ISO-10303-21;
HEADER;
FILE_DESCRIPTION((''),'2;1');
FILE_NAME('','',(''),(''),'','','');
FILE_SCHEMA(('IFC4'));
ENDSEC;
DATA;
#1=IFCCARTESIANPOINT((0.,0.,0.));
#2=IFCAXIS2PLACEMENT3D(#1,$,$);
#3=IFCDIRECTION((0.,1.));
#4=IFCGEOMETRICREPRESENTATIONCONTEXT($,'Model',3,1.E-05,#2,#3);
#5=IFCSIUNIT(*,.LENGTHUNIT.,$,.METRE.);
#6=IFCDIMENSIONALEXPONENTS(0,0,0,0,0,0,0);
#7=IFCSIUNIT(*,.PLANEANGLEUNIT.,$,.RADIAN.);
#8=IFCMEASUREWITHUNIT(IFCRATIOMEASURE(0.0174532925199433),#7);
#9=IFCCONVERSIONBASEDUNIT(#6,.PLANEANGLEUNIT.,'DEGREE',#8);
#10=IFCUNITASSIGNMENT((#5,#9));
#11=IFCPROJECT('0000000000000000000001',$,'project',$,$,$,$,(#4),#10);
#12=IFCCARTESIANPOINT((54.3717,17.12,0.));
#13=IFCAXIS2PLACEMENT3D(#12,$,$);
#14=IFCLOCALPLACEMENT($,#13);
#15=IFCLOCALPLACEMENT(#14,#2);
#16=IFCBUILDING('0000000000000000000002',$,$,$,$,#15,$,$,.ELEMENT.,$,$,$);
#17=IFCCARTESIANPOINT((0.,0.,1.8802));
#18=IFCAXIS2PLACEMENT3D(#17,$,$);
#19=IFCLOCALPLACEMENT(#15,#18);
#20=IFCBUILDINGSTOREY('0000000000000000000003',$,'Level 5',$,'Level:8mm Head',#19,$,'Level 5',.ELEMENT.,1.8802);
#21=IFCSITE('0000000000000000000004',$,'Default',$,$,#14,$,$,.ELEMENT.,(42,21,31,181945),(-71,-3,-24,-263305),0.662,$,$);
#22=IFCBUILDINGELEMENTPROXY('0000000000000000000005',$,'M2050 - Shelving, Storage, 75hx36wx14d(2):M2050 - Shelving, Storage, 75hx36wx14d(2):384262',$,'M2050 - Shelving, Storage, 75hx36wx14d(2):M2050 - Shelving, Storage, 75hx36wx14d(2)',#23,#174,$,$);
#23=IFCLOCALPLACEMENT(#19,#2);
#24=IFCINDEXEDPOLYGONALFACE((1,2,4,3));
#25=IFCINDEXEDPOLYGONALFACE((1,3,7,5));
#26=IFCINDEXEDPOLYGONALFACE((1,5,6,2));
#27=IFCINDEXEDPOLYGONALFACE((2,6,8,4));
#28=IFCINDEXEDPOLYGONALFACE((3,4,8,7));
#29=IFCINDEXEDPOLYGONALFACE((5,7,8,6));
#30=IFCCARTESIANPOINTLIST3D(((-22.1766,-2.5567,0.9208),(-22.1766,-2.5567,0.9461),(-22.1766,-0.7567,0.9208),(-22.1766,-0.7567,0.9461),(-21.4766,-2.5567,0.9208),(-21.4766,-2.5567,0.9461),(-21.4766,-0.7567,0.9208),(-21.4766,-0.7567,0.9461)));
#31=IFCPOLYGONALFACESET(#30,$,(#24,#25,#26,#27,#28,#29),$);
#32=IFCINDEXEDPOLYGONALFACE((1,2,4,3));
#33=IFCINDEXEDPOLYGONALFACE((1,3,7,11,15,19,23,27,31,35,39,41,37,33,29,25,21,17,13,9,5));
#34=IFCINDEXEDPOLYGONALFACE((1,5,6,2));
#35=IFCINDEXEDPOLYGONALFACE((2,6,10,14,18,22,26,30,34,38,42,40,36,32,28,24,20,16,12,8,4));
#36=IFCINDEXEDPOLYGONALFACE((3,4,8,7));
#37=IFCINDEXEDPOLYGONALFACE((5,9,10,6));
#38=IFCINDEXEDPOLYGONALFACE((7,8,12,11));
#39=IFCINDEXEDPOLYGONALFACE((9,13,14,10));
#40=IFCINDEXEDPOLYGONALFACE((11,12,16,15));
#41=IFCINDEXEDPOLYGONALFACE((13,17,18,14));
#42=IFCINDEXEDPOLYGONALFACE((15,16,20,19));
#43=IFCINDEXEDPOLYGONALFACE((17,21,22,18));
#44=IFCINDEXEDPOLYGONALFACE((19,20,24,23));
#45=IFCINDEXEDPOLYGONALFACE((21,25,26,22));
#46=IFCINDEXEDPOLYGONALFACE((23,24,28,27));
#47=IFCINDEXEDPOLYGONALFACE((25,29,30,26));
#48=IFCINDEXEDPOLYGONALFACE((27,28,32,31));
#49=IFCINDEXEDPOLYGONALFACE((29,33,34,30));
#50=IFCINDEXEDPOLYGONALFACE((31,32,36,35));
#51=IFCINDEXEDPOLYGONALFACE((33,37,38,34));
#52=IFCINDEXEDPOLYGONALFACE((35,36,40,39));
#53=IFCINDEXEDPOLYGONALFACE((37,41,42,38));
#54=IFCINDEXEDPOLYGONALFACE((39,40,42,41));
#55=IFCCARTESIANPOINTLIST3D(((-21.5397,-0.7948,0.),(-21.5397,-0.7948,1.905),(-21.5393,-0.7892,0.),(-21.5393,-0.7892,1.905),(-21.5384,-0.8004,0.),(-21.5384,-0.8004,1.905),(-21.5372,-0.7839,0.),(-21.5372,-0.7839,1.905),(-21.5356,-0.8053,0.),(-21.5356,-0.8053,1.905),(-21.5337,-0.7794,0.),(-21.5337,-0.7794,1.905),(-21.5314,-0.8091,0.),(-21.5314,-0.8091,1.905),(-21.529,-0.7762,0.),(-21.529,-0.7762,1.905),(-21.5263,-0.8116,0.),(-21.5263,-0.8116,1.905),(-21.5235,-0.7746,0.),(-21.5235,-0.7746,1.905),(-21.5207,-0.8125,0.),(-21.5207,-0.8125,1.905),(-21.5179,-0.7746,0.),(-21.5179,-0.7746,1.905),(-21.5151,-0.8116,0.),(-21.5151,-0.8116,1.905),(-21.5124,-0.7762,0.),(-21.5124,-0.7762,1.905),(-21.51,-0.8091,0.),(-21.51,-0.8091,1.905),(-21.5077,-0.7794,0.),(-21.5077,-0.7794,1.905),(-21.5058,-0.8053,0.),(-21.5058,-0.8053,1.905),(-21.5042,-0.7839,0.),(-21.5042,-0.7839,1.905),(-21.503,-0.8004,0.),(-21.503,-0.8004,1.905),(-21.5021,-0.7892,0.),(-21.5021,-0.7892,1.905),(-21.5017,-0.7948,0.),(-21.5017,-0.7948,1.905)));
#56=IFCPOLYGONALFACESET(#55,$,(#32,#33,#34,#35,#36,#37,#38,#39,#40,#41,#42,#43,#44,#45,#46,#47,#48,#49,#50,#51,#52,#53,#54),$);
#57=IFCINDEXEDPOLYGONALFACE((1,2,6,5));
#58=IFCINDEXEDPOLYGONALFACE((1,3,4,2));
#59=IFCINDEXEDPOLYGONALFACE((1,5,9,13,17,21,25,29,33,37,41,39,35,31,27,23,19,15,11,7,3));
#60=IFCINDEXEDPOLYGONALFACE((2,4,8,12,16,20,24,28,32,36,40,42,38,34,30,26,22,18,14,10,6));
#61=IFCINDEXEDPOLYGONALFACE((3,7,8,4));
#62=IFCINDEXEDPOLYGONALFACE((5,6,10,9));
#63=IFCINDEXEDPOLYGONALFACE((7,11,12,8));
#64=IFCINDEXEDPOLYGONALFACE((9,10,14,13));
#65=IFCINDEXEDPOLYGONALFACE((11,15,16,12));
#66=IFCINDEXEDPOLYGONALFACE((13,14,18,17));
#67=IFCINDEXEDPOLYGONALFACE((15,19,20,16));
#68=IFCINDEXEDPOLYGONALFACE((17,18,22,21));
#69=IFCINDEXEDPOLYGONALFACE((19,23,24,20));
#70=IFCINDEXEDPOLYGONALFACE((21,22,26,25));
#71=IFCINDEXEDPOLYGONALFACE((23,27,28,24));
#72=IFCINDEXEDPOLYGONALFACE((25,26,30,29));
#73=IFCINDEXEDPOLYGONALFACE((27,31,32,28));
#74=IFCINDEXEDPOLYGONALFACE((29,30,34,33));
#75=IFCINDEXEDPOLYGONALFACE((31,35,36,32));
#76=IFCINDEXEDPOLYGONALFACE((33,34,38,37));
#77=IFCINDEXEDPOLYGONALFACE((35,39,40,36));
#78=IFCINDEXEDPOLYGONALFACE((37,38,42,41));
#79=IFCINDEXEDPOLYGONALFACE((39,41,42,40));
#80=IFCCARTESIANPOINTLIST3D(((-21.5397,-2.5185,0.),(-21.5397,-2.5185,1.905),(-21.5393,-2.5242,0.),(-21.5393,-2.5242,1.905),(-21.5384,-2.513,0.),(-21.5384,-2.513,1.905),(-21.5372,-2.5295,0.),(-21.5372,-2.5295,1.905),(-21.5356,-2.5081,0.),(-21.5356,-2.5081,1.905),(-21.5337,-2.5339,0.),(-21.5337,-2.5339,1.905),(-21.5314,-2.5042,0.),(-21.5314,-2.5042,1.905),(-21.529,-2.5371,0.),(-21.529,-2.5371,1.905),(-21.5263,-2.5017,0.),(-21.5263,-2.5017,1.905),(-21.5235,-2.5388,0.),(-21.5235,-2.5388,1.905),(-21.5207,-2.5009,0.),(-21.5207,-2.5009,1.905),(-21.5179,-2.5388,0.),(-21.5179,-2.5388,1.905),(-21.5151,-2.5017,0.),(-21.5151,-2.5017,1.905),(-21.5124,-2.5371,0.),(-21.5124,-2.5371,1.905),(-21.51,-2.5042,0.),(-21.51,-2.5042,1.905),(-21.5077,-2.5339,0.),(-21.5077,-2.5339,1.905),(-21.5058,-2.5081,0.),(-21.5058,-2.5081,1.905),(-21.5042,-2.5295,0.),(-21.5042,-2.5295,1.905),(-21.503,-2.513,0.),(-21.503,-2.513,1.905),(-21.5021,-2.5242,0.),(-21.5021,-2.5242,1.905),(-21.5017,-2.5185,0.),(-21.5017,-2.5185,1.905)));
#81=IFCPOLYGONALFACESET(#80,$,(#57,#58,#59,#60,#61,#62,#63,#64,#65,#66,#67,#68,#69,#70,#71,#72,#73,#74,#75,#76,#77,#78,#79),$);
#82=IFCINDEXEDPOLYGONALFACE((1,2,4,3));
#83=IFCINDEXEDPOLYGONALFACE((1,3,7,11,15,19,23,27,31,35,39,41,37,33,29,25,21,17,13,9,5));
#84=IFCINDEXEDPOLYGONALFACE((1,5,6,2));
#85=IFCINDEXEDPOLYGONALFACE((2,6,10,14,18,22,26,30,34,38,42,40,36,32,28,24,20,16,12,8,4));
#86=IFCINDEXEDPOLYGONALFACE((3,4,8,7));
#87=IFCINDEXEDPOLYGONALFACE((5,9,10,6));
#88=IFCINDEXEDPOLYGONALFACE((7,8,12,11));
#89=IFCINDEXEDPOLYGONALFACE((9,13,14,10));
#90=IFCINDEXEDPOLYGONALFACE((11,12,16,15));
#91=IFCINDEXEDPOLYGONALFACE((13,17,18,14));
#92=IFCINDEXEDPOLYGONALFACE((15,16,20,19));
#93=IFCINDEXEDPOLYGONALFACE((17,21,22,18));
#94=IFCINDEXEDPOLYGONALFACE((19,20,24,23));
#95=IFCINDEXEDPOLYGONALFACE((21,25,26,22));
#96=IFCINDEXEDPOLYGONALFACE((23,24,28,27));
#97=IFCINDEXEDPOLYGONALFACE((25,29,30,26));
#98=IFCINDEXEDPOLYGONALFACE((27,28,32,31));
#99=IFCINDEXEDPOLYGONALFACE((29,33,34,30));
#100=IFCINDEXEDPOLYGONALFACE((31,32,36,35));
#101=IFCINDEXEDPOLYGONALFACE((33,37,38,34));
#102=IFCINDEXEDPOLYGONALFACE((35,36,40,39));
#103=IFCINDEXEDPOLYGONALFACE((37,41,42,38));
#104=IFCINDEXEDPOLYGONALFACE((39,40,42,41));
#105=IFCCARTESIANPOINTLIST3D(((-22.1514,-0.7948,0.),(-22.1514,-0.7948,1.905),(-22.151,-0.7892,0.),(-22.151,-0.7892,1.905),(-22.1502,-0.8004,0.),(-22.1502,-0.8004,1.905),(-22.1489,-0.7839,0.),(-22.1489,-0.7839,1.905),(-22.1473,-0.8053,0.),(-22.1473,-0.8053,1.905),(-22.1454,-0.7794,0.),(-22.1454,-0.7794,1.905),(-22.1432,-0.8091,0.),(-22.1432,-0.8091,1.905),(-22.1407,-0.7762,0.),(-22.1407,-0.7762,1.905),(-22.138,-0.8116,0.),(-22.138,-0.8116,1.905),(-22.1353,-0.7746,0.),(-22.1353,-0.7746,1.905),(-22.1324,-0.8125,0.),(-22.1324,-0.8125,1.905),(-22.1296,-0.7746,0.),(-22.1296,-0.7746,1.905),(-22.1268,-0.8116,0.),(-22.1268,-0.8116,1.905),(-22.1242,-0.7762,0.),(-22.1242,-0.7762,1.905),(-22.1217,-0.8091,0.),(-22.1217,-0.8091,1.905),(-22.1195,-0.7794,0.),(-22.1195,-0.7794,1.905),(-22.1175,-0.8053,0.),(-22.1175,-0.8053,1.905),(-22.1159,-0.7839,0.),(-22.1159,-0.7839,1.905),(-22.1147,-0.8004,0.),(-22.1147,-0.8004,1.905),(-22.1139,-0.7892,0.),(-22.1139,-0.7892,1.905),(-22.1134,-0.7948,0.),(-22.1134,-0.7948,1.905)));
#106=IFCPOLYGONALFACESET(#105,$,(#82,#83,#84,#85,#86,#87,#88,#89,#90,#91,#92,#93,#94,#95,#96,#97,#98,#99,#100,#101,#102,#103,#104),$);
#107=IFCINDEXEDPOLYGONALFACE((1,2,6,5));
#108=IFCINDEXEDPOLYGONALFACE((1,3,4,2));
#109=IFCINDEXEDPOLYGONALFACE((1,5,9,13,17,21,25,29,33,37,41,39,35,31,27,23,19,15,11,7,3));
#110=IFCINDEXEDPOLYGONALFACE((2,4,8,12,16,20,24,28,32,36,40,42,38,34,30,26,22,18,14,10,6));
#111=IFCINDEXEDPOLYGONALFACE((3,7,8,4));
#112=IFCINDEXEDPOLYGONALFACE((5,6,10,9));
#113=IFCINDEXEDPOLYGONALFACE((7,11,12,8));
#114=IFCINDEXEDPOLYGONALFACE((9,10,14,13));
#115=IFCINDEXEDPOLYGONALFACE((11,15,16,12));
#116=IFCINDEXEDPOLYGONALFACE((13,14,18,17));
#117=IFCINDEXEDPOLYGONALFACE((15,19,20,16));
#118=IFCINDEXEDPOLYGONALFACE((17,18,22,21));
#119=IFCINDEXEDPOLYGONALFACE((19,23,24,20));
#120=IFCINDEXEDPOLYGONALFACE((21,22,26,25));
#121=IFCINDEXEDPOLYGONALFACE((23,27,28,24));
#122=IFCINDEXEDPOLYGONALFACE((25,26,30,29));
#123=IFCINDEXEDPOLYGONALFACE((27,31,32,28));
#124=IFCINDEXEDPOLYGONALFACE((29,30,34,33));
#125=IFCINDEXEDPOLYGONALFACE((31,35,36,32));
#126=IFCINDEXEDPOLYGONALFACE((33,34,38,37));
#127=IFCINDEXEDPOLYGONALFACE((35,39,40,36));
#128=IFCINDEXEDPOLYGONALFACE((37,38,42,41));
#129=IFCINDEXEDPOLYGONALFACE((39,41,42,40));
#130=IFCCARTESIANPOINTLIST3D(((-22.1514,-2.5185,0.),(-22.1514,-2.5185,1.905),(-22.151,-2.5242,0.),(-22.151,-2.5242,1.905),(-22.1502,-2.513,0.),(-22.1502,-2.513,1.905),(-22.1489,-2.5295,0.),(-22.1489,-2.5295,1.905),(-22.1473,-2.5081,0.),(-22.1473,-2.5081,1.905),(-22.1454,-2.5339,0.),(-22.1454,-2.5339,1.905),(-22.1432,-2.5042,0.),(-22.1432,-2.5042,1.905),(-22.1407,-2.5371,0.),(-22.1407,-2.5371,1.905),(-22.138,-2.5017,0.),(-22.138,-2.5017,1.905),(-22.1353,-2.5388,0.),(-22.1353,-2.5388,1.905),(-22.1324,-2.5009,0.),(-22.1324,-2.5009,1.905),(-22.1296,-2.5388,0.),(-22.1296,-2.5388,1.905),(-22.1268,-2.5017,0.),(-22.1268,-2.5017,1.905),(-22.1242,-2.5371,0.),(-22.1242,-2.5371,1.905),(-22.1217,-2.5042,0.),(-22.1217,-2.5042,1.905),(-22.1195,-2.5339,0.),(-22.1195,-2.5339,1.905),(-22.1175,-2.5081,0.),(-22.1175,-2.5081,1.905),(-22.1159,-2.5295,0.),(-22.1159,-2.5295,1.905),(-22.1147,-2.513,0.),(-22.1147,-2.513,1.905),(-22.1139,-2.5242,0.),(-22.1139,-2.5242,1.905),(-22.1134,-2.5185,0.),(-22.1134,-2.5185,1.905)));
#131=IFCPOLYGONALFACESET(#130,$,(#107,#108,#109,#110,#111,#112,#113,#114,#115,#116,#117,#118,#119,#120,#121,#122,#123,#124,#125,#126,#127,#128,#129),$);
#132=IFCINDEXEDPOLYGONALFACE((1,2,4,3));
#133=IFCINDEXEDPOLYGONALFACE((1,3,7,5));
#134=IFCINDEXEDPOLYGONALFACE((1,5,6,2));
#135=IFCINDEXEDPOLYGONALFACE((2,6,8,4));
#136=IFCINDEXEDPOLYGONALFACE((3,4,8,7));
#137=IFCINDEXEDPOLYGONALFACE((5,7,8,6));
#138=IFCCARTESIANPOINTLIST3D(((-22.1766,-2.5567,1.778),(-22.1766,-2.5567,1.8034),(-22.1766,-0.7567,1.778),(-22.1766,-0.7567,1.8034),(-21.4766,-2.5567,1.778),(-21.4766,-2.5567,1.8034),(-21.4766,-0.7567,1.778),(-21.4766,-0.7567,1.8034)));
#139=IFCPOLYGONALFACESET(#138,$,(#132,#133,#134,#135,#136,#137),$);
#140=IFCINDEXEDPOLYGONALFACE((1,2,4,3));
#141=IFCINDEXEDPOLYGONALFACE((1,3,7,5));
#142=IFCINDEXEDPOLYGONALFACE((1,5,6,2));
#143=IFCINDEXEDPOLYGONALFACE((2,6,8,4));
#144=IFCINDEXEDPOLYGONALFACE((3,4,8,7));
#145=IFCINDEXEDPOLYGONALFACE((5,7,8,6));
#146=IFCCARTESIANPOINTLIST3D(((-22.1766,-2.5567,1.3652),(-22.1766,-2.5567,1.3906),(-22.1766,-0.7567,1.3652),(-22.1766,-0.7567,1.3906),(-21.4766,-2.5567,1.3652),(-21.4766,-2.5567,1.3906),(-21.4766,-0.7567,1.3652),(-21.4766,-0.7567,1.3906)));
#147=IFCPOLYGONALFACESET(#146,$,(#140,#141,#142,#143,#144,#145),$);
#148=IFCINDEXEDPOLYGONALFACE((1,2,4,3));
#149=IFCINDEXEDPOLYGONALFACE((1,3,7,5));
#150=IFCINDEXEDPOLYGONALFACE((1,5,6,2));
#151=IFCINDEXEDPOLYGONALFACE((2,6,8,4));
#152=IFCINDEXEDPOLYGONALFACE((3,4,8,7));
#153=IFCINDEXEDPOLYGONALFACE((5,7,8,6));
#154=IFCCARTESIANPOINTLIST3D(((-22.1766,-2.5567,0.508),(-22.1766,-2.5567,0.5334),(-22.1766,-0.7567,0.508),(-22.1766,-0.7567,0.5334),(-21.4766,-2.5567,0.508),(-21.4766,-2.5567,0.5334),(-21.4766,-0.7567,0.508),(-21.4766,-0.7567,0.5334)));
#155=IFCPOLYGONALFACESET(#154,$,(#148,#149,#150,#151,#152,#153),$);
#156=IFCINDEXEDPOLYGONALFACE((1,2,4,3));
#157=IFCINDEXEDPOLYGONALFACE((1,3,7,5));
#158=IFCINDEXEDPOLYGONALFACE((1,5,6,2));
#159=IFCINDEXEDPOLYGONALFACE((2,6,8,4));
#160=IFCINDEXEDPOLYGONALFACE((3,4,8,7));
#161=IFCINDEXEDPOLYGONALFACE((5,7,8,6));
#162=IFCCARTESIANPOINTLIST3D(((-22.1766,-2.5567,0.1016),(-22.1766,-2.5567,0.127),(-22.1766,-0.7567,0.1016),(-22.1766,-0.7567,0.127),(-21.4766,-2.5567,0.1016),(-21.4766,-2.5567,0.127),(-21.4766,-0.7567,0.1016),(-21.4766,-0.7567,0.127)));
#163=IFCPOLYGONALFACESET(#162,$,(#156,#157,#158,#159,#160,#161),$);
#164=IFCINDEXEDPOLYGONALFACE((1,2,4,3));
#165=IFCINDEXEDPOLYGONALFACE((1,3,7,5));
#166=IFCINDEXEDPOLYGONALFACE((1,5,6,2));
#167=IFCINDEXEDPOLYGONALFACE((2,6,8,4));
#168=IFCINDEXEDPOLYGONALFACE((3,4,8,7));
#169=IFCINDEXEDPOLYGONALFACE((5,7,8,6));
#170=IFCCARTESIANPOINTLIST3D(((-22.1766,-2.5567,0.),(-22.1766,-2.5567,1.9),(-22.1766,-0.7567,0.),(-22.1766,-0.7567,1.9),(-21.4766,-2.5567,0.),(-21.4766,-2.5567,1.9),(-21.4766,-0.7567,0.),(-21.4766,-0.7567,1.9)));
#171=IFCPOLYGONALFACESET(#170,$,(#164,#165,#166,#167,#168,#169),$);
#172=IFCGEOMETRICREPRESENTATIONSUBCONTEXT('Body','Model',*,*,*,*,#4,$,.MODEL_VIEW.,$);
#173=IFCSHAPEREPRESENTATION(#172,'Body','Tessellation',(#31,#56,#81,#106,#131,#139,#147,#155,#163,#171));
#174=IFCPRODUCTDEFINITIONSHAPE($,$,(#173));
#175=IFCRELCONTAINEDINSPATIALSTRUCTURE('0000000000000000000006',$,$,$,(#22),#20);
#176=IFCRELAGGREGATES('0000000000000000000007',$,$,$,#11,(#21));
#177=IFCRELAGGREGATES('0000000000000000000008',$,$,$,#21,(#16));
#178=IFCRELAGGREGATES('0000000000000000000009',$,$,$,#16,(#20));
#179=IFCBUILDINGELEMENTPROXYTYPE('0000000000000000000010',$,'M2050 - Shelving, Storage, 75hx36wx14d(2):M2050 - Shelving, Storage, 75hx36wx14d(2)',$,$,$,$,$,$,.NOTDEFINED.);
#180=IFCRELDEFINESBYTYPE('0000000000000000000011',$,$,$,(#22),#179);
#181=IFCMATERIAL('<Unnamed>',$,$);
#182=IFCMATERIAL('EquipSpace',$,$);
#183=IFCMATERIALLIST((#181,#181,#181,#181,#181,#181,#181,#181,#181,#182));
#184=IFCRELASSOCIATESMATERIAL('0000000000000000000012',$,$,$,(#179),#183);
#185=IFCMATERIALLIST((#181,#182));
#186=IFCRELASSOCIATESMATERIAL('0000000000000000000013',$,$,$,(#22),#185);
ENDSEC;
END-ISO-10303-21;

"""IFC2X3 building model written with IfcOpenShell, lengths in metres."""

from ifc_helpers import new_model, entity, si_unit, converted_unit, direction, frame, frame_2d, origin, origin_2d_with_axis, place, context, subcontext, project, spatial, rectangle, circle, extrude, source, transform, mapped, material, material_list, type_object, type_shapes, element, save


model = new_model("IFC2X3")

# Units and contexts
model_context = context("Model", 3, precision=1e-05, world=origin(), true_north=direction((0.0, 1.0)))
body_context = subcontext(model_context, "Body", "Model", "MODEL_VIEW")
ifc_project = project(units=[si_unit("LENGTHUNIT", "METRE"), converted_unit("PLANEANGLEUNIT", "DEGREE", entity("IfcRatioMeasure", 0.0174532925199433), si_unit("PLANEANGLEUNIT", "RADIAN"), dimensions=[0, 0, 0, 0, 0, 0, 0])], contexts=[model_context])

# Site, building, storey
site_placement = place(None, frame((54.3717, 17.12, 0.0)))
site = spatial("IfcSite", under=ifc_project, at=site_placement, Name="Default", CompositionType="ELEMENT", RefLatitude=(42, 21, 31, 181945), RefLongitude=(-71, -3, -24, -263305), RefElevation=0.662)
building_placement = place(site_placement, origin())
building = spatial("IfcBuilding", under=site, at=building_placement, CompositionType="ELEMENT")
storey_placement = place(building_placement, frame((0.0, 0.0, 1.8802)))
storey = spatial("IfcBuildingStorey", under=building, at=storey_placement, Name="Level 5", ObjectType="Level:8mm Head", LongName="Level 5", CompositionType="ELEMENT", Elevation=1.8802)

# Building element proxy
ifc_material_1 = material(Name="<Unnamed>")
ifc_material_2 = material(Name="EquipSpace")
ifc_material_list_1 = material_list([ifc_material_1, ifc_material_1, ifc_material_1, ifc_material_1, ifc_material_1, ifc_material_1, ifc_material_1, ifc_material_1, ifc_material_1, ifc_material_2])
building_element_proxy_type = type_object("IfcBuildingElementProxyType", Name="M2050 - Shelving, Storage, 75hx36wx14d(2):M2050 - Shelving, Storage, 75hx36wx14d(2)", PredefinedType="NOTDEFINED", material=ifc_material_list_1)
shared_shape = source(origin(), body_context, "Body", "SweptSolid", [
    extrude(rectangle(XDim=1.8, YDim=0.7, at=origin_2d_with_axis()), frame((0.0, 0.0, 0.9207), z_axis=(0.0, 0.0, 1.0), x_axis=(-1.0, 0.0, 0.0)), (0.0, 0.0, 1.0), 0.0254),
    extrude(circle(Radius=0.0191, at=origin_2d_with_axis()), frame((0.8633, -0.3059, 0.0), z_axis=(0.0, 0.0, 1.0), x_axis=(-1.0, 0.0, 0.0)), (0.0, 0.0, 1.0), 1.905),
    extrude(circle(Radius=0.0191, at=origin_2d_with_axis()), frame((-0.8633, -0.3059, 0.0)), (0.0, 0.0, 1.0), 1.905),
    extrude(circle(Radius=0.0191, at=origin_2d_with_axis()), frame((0.8633, 0.3059, 0.0), z_axis=(0.0, 0.0, 1.0), x_axis=(-1.0, 0.0, 0.0)), (0.0, 0.0, 1.0), 1.905),
    extrude(circle(Radius=0.0191, at=origin_2d_with_axis()), frame((-0.8633, 0.3059, 0.0)), (0.0, 0.0, 1.0), 1.905),
    extrude(rectangle(XDim=1.8, YDim=0.7, at=origin_2d_with_axis()), frame((0.0, 0.0, 1.778), z_axis=(0.0, 0.0, 1.0), x_axis=(-1.0, 0.0, 0.0)), (0.0, 0.0, 1.0), 0.0254),
    extrude(rectangle(XDim=1.8, YDim=0.7, at=origin_2d_with_axis()), frame((0.0, 0.0, 1.3653), z_axis=(0.0, 0.0, 1.0), x_axis=(-1.0, 0.0, 0.0)), (0.0, 0.0, 1.0), 0.0254),
    extrude(rectangle(XDim=1.8, YDim=0.7, at=origin_2d_with_axis()), frame((0.0, 0.0, 0.508), z_axis=(0.0, 0.0, 1.0), x_axis=(-1.0, 0.0, 0.0)), (0.0, 0.0, 1.0), 0.0254),
    extrude(rectangle(XDim=1.8, YDim=0.7, at=origin_2d_with_axis()), frame((0.0, 0.0, 0.1016), z_axis=(0.0, 0.0, 1.0), x_axis=(-1.0, 0.0, 0.0)), (0.0, 0.0, 1.0), 0.0254),
    extrude(rectangle(XDim=0.7, YDim=1.8, at=frame_2d((0.0, 0.18), x_axis=(1.0, 0.0))), frame((-0.18, 0.0, 0.0), z_axis=(0.0, 0.0, 1.0), x_axis=(0.0, -1.0, 0.0)), (0.0, 0.0, 1.0), 1.9),
])
type_shapes(building_element_proxy_type, [shared_shape])
ifc_material_list_2 = material_list([ifc_material_1, ifc_material_2])
proxy_1_placement = place(storey_placement, frame((-21.8266, -1.6567, 0.0), z_axis=(0.0, 0.0, 1.0), x_axis=(0.0, 1.0, 0.0)))
element("IfcBuildingElementProxy", 1, at=proxy_1_placement, inside=storey, type_object=building_element_proxy_type, material=ifc_material_list_2, Name="M2050 - Shelving, Storage, 75hx36wx14d(2):M2050 - Shelving, Storage, 75hx36wx14d(2):384262", ObjectType="M2050 - Shelving, Storage, 75hx36wx14d(2):M2050 - Shelving, Storage, 75hx36wx14d(2)", context=body_context, shape_type="MappedRepresentation", body=[
    mapped(shared_shape, transform((0.0, 0.0, 0.0), scale=1.0)),
])

save(model, "model.ifc")
